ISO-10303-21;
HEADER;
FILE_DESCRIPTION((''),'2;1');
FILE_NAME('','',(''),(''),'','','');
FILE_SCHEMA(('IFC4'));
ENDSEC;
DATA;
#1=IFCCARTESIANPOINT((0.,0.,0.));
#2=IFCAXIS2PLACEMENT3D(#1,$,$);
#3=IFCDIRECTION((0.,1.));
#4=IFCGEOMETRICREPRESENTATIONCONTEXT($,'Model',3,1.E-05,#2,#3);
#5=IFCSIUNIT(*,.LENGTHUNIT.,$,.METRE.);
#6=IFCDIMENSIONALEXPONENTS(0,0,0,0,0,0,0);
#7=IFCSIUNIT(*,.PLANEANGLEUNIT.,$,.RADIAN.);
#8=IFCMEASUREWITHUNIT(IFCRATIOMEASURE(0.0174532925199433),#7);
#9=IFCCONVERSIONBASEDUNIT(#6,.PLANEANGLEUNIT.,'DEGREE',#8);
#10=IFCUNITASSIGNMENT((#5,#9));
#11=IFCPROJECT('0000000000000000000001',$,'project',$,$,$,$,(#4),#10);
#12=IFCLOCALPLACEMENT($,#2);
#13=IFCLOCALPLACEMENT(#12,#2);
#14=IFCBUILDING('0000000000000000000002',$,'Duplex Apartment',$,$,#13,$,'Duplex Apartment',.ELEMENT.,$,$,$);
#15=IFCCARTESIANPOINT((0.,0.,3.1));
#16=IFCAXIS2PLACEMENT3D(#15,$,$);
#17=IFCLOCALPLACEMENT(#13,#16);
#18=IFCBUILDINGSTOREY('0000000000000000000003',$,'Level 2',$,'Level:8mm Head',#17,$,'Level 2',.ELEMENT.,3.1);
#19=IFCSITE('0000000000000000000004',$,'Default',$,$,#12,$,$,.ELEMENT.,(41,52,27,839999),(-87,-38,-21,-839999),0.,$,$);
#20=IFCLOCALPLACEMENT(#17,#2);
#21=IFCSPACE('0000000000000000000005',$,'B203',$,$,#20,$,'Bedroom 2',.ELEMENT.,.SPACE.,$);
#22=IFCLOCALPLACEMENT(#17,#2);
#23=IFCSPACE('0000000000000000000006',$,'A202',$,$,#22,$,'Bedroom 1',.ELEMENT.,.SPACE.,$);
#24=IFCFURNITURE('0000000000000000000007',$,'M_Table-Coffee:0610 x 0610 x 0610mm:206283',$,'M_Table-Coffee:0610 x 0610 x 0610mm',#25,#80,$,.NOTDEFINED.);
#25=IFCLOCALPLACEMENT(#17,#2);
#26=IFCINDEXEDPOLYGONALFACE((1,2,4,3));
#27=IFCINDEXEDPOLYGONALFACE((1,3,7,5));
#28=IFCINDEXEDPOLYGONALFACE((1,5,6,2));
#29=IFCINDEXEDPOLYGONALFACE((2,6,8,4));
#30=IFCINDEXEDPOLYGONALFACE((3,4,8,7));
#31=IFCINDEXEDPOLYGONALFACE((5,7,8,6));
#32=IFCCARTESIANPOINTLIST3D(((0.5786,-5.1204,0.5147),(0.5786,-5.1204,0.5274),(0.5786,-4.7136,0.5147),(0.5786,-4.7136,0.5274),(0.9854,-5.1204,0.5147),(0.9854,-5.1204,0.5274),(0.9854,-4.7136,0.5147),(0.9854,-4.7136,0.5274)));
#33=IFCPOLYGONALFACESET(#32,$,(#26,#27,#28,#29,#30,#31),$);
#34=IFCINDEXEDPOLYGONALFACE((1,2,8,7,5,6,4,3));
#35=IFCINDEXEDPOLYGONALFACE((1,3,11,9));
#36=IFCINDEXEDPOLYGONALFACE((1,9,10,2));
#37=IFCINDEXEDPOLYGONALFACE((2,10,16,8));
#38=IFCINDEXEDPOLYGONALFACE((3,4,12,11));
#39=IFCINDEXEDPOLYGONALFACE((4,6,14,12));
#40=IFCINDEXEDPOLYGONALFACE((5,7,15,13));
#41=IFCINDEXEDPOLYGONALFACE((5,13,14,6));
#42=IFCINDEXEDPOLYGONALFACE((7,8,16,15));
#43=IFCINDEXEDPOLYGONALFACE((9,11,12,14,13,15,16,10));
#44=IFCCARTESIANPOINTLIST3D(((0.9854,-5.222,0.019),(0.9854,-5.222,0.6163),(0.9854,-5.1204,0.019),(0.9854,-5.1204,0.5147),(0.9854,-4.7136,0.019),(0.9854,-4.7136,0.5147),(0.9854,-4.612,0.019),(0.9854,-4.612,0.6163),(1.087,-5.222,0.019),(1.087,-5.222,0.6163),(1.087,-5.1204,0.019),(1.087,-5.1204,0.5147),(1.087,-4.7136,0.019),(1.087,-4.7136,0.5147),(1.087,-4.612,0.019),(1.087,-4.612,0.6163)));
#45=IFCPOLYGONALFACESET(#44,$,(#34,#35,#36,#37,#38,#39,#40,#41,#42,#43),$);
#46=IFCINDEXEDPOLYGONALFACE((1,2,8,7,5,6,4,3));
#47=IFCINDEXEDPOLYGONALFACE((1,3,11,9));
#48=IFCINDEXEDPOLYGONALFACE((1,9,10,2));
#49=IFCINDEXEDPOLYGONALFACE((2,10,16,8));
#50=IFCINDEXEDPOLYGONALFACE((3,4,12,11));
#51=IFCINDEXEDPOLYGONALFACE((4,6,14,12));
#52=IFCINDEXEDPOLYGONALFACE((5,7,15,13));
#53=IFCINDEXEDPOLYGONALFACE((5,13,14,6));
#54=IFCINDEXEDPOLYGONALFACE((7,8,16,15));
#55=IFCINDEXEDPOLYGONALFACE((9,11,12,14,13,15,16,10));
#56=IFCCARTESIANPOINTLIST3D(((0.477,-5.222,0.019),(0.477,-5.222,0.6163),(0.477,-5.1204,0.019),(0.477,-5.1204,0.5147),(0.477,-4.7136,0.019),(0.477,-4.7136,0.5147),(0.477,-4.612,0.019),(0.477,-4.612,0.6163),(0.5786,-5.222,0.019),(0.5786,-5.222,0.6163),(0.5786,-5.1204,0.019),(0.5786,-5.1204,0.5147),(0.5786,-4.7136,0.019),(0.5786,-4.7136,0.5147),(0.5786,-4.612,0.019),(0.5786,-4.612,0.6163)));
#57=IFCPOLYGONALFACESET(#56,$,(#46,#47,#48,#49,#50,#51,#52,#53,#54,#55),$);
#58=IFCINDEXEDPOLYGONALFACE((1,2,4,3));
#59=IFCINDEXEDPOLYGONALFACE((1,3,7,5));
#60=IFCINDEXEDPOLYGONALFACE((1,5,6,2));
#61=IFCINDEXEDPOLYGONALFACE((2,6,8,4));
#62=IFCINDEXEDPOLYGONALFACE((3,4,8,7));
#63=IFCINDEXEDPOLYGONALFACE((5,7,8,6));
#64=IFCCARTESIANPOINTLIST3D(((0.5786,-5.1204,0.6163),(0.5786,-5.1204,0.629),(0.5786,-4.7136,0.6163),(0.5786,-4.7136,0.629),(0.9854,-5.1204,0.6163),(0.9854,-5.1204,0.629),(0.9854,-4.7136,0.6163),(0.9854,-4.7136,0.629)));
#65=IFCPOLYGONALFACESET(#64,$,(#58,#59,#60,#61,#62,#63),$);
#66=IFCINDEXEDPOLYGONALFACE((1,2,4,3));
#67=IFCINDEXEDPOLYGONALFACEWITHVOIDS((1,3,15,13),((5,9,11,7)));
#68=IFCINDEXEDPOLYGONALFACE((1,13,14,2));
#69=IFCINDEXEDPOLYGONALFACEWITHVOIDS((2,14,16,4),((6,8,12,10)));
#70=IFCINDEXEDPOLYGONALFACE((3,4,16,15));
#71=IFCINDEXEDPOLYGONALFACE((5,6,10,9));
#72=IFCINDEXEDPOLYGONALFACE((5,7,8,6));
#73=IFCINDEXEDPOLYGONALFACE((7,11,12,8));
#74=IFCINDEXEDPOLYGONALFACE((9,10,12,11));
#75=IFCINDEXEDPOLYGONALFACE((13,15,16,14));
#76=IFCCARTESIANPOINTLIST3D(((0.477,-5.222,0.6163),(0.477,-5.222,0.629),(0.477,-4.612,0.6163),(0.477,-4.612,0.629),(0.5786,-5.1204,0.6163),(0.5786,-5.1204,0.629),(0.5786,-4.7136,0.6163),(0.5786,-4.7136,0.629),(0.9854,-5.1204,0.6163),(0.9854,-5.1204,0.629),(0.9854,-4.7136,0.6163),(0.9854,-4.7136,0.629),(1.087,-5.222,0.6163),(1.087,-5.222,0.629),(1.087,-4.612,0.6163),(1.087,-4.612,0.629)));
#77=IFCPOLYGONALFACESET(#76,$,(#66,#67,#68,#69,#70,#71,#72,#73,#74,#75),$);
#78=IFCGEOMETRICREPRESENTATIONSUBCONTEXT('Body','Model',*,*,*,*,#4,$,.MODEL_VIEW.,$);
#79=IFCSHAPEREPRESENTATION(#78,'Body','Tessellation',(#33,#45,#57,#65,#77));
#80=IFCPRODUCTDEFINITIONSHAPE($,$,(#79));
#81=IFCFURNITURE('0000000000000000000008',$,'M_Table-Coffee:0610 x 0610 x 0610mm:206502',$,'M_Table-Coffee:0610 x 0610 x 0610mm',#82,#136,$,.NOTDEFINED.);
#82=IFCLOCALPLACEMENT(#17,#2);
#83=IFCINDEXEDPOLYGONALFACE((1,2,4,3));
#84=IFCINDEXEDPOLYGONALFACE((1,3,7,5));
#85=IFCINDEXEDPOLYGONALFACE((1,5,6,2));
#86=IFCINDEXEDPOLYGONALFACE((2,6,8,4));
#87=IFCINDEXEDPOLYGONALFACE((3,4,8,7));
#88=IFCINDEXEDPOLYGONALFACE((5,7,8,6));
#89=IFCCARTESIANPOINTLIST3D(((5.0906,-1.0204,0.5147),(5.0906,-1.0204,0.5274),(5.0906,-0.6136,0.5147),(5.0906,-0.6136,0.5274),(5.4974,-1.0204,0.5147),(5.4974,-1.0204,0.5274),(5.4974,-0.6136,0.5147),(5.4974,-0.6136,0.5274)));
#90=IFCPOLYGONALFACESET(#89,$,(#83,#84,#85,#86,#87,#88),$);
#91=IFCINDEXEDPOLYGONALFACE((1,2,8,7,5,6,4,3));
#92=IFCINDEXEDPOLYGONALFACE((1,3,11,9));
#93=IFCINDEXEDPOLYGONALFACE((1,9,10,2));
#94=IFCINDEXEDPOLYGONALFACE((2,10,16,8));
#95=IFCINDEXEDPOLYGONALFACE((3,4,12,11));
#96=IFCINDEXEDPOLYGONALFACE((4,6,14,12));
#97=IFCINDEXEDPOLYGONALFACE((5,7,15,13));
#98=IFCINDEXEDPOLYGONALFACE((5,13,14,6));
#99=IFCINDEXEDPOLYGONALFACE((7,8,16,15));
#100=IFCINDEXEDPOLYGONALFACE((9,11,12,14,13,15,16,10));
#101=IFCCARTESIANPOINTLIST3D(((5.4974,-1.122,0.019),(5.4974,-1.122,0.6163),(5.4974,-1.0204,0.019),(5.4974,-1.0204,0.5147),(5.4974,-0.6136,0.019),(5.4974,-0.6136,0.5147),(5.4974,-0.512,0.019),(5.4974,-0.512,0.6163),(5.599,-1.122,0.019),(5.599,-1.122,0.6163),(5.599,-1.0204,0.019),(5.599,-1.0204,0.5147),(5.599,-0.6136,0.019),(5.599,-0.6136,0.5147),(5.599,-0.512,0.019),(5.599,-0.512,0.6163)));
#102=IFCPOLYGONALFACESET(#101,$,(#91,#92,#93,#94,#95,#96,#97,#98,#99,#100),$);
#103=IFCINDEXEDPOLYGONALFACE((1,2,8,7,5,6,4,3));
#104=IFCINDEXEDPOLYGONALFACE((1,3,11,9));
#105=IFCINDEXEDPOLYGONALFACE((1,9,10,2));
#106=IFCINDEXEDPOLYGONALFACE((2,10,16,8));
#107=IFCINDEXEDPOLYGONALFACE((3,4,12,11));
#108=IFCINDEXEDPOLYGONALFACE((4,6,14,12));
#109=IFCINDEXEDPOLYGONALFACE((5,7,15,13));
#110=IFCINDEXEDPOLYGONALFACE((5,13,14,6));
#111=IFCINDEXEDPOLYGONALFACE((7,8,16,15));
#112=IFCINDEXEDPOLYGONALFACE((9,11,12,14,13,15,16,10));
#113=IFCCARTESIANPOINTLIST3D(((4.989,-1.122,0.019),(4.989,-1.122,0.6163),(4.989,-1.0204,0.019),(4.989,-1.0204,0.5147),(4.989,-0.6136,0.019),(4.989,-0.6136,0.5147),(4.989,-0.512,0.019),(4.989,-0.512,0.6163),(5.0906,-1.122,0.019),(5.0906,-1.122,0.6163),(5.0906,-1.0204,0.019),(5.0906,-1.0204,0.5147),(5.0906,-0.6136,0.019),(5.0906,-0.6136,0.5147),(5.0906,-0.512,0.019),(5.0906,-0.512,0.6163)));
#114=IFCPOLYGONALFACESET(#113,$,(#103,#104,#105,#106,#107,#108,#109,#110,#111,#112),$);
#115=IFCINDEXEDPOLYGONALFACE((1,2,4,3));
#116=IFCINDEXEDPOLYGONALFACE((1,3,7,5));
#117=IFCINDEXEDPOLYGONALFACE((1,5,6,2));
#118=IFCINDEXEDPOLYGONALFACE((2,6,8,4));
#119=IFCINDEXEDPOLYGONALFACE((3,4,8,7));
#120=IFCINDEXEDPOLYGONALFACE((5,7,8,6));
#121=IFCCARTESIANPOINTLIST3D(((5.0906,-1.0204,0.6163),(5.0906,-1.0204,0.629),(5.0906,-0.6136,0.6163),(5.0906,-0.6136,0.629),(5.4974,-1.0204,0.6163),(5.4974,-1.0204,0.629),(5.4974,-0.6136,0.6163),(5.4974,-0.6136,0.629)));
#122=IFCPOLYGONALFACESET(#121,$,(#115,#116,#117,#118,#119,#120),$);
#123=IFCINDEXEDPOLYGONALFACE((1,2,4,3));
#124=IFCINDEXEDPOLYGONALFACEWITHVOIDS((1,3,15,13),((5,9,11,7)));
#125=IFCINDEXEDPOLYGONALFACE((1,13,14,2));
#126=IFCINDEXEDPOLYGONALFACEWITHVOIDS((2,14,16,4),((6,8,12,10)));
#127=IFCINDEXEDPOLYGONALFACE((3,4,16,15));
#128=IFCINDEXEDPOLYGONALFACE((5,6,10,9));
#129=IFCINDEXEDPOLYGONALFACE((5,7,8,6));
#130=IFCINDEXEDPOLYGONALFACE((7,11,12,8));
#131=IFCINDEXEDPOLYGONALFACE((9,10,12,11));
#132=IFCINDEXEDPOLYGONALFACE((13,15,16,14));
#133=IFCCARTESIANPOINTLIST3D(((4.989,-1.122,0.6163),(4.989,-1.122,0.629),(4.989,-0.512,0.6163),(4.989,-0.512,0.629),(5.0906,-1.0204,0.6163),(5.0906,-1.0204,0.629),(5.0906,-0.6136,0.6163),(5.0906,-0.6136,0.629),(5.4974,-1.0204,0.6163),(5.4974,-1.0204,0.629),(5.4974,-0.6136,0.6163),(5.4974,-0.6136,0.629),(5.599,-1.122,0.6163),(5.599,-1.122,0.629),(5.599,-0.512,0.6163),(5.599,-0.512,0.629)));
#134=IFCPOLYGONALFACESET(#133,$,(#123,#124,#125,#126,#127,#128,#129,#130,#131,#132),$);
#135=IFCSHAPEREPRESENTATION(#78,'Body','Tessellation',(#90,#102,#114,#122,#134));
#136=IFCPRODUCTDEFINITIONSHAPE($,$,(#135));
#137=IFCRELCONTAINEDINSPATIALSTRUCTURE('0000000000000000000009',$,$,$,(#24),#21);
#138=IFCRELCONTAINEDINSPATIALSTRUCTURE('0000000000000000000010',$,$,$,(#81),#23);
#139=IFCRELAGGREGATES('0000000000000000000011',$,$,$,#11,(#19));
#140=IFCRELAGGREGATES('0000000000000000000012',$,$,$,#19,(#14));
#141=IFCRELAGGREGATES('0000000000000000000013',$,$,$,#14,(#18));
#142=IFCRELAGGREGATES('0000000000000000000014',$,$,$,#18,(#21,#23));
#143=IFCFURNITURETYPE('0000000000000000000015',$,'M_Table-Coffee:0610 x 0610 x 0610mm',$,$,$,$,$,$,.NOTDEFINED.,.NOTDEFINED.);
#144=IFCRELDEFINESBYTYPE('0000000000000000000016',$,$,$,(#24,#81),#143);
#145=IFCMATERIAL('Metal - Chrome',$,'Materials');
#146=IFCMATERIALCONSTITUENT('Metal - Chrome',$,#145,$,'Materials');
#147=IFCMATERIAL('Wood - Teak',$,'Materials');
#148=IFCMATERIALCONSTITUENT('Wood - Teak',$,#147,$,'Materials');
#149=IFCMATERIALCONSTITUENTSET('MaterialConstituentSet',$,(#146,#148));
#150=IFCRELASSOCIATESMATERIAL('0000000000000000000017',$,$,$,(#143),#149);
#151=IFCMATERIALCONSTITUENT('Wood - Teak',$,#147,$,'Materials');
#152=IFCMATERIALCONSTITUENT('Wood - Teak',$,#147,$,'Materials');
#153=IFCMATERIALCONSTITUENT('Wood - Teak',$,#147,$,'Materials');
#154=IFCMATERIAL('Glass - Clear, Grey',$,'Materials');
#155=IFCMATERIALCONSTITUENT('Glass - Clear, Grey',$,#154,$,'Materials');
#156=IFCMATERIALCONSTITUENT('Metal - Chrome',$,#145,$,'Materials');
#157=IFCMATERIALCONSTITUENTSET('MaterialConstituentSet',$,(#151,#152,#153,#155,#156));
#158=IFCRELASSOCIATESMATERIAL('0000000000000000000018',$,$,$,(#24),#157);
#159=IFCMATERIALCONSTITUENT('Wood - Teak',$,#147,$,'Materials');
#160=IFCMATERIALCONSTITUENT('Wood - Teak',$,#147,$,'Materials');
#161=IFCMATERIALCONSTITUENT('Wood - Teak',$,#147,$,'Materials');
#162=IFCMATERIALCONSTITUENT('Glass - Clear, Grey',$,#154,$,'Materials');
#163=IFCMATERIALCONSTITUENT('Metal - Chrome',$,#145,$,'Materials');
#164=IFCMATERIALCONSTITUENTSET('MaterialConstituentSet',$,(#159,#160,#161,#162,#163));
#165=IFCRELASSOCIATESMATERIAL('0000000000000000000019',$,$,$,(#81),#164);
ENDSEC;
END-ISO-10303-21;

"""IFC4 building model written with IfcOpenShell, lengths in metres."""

from ifc_helpers import new_model, entity, si_unit, converted_unit, direction, frame, origin, place, context, subcontext, project, spatial, indexed_curve, outline, extrude, source, transform, mapped, material, constituent, constituent_set, type_object, type_shapes, element, save


model = new_model("IFC4")

# Units and contexts
model_context = context("Model", 3, precision=1e-05, world=origin(), true_north=direction((0.0, 1.0)))
body_context = subcontext(model_context, "Body", "Model", "MODEL_VIEW")
ifc_project = project(units=[si_unit("LENGTHUNIT", "METRE"), converted_unit("PLANEANGLEUNIT", "DEGREE", entity("IfcRatioMeasure", 0.0174532925199433), si_unit("PLANEANGLEUNIT", "RADIAN"), dimensions=[0, 0, 0, 0, 0, 0, 0])], contexts=[model_context])

# Site, building, storey
site_placement = place(None, origin())
site = spatial("IfcSite", under=ifc_project, at=site_placement, Name="Default", CompositionType="ELEMENT", RefLatitude=(41, 52, 27, 839999), RefLongitude=(-87, -38, -21, -839999), RefElevation=0.0)
building_placement = place(site_placement, origin())
building = spatial("IfcBuilding", under=site, at=building_placement, Name="Duplex Apartment", LongName="Duplex Apartment", CompositionType="ELEMENT")
storey_placement = place(building_placement, frame((0.0, 0.0, 3.1)))
storey = spatial("IfcBuildingStorey", under=building, at=storey_placement, Name="Level 2", ObjectType="Level:8mm Head", LongName="Level 2", CompositionType="ELEMENT", Elevation=3.1)

# Shared definitions
space_1_placement = place(storey_placement, origin())
space_1 = spatial("IfcSpace", under=storey, at=space_1_placement, Name="B203", LongName="Bedroom 2", CompositionType="ELEMENT", PredefinedType="SPACE")

# Shared definitions
space_2_placement = place(storey_placement, origin())
space_2 = spatial("IfcSpace", under=storey, at=space_2_placement, Name="A202", LongName="Bedroom 1", CompositionType="ELEMENT", PredefinedType="SPACE")

# Furniture
ifc_material_1 = material(Name="Wood - Teak", Category="Materials")
ifc_constituent_1 = constituent(ifc_material_1, Name="Wood - Teak", Category="Materials")
ifc_constituent_2 = constituent(ifc_material_1, Name="Wood - Teak", Category="Materials")
ifc_constituent_3 = constituent(ifc_material_1, Name="Wood - Teak", Category="Materials")
ifc_material_2 = material(Name="Glass - Clear, Grey", Category="Materials")
ifc_constituent_4 = constituent(ifc_material_2, Name="Glass - Clear, Grey", Category="Materials")
ifc_material_3 = material(Name="Metal - Chrome", Category="Materials")
ifc_constituent_5 = constituent(ifc_material_3, Name="Metal - Chrome", Category="Materials")
ifc_constituent_set_1 = constituent_set(constituents=[ifc_constituent_1, ifc_constituent_2, ifc_constituent_3, ifc_constituent_4, ifc_constituent_5], Name="MaterialConstituentSet")
ifc_constituent_6 = constituent(ifc_material_3, Name="Metal - Chrome", Category="Materials")
ifc_constituent_7 = constituent(ifc_material_1, Name="Wood - Teak", Category="Materials")
ifc_constituent_set_2 = constituent_set(constituents=[ifc_constituent_6, ifc_constituent_7], Name="MaterialConstituentSet")
furniture_type_1 = type_object("IfcFurnitureType", Name="M_Table-Coffee:0610 x 0610 x 0610mm", AssemblyPlace="NOTDEFINED", PredefinedType="NOTDEFINED", material=ifc_constituent_set_2)
shared_shape_1 = source(origin(), body_context, "Body", "SweptSolid", [
    extrude(outline(indexed_curve([(-0.2034, -0.2034), (0.2034, -0.2034), (0.2034, 0.2034), (-0.2034, 0.2034), (-0.2034, -0.2034)], self_intersect=False)), frame((0.0183, 0.0952, 0.4957), z_axis=(0.0, 0.0, 1.0), x_axis=(-1.0, 0.0, 0.0)), (0.0, 0.0, 1.0), 0.0127),
    extrude(outline(indexed_curve([(-0.2732, -0.305), (0.324, -0.305), (0.324, 0.305), (-0.2732, 0.305), (-0.2732, 0.2034), (0.2225, 0.2034), (0.2225, -0.2034), (-0.2732, -0.2034), (-0.2732, -0.305)], self_intersect=False)), frame((0.2217, 0.0952, 0.2732), z_axis=(1.0, 0.0, 0.0), x_axis=(0.0, 0.0, 1.0)), (0.0, 0.0, 1.0), 0.1016),
    extrude(outline(indexed_curve([(-0.305, -0.3241), (0.305, -0.3241), (0.305, 0.2733), (0.2034, 0.2733), (0.2034, -0.2224), (-0.2034, -0.2224), (-0.2034, 0.2733), (-0.305, 0.2733), (-0.305, -0.3241)], self_intersect=False)), frame((-0.2867, 0.0952, 0.2733), z_axis=(1.0, 0.0, 0.0), x_axis=(0.0, -1.0, 0.0)), (0.0, 0.0, 1.0), 0.1016),
    extrude(outline(indexed_curve([(-0.2034, -0.2034), (0.2034, -0.2034), (0.2034, 0.2034), (-0.2034, 0.2034), (-0.2034, -0.2034)], self_intersect=False)), frame((0.0183, 0.0952, 0.5973), z_axis=(0.0, 0.0, 1.0), x_axis=(-1.0, 0.0, 0.0)), (0.0, 0.0, 1.0), 0.0127),
    extrude(outline(indexed_curve([(-0.305, -0.305), (0.305, -0.305), (0.305, 0.305), (-0.305, 0.305), (-0.305, -0.305)], self_intersect=False), holes=[indexed_curve([(-0.2034, -0.2034), (-0.2034, 0.2034), (0.2034, 0.2034), (0.2034, -0.2034), (-0.2034, -0.2034)], self_intersect=False)]), frame((0.0183, 0.0952, 0.5973), z_axis=(0.0, 0.0, 1.0), x_axis=(-1.0, 0.0, 0.0)), (0.0, 0.0, 1.0), 0.0127),
])
type_shapes(furniture_type_1, [shared_shape_1])
furniture_1_placement = place(space_1_placement, frame((0.7637, -5.0122, 0.019)))
element("IfcFurniture", 1, at=furniture_1_placement, inside=space_1, type_object=furniture_type_1, material=ifc_constituent_set_1, Name="M_Table-Coffee:0610 x 0610 x 0610mm:206283", ObjectType="M_Table-Coffee:0610 x 0610 x 0610mm", PredefinedType="NOTDEFINED", context=body_context, shape_type="MappedRepresentation", body=[
    mapped(shared_shape_1, transform((0.0, 0.0, 0.0), scale=1.0)),
])
ifc_constituent_8 = constituent(ifc_material_1, Name="Wood - Teak", Category="Materials")
ifc_constituent_9 = constituent(ifc_material_1, Name="Wood - Teak", Category="Materials")
ifc_constituent_10 = constituent(ifc_material_1, Name="Wood - Teak", Category="Materials")
ifc_constituent_11 = constituent(ifc_material_2, Name="Glass - Clear, Grey", Category="Materials")
ifc_constituent_12 = constituent(ifc_material_3, Name="Metal - Chrome", Category="Materials")
ifc_constituent_set_3 = constituent_set(constituents=[ifc_constituent_8, ifc_constituent_9, ifc_constituent_10, ifc_constituent_11, ifc_constituent_12], Name="MaterialConstituentSet")
furniture_2_placement = place(space_2_placement, frame((5.2757, -0.9122, 0.019)))
element("IfcFurniture", 2, at=furniture_2_placement, inside=space_2, type_object=furniture_type_1, material=ifc_constituent_set_3, Name="M_Table-Coffee:0610 x 0610 x 0610mm:206502", ObjectType="M_Table-Coffee:0610 x 0610 x 0610mm", PredefinedType="NOTDEFINED", context=body_context, shape_type="MappedRepresentation", body=[
    mapped(shared_shape_1, transform((0.0, 0.0, 0.0), scale=1.0)),
])

save(model, "model.ifc")
